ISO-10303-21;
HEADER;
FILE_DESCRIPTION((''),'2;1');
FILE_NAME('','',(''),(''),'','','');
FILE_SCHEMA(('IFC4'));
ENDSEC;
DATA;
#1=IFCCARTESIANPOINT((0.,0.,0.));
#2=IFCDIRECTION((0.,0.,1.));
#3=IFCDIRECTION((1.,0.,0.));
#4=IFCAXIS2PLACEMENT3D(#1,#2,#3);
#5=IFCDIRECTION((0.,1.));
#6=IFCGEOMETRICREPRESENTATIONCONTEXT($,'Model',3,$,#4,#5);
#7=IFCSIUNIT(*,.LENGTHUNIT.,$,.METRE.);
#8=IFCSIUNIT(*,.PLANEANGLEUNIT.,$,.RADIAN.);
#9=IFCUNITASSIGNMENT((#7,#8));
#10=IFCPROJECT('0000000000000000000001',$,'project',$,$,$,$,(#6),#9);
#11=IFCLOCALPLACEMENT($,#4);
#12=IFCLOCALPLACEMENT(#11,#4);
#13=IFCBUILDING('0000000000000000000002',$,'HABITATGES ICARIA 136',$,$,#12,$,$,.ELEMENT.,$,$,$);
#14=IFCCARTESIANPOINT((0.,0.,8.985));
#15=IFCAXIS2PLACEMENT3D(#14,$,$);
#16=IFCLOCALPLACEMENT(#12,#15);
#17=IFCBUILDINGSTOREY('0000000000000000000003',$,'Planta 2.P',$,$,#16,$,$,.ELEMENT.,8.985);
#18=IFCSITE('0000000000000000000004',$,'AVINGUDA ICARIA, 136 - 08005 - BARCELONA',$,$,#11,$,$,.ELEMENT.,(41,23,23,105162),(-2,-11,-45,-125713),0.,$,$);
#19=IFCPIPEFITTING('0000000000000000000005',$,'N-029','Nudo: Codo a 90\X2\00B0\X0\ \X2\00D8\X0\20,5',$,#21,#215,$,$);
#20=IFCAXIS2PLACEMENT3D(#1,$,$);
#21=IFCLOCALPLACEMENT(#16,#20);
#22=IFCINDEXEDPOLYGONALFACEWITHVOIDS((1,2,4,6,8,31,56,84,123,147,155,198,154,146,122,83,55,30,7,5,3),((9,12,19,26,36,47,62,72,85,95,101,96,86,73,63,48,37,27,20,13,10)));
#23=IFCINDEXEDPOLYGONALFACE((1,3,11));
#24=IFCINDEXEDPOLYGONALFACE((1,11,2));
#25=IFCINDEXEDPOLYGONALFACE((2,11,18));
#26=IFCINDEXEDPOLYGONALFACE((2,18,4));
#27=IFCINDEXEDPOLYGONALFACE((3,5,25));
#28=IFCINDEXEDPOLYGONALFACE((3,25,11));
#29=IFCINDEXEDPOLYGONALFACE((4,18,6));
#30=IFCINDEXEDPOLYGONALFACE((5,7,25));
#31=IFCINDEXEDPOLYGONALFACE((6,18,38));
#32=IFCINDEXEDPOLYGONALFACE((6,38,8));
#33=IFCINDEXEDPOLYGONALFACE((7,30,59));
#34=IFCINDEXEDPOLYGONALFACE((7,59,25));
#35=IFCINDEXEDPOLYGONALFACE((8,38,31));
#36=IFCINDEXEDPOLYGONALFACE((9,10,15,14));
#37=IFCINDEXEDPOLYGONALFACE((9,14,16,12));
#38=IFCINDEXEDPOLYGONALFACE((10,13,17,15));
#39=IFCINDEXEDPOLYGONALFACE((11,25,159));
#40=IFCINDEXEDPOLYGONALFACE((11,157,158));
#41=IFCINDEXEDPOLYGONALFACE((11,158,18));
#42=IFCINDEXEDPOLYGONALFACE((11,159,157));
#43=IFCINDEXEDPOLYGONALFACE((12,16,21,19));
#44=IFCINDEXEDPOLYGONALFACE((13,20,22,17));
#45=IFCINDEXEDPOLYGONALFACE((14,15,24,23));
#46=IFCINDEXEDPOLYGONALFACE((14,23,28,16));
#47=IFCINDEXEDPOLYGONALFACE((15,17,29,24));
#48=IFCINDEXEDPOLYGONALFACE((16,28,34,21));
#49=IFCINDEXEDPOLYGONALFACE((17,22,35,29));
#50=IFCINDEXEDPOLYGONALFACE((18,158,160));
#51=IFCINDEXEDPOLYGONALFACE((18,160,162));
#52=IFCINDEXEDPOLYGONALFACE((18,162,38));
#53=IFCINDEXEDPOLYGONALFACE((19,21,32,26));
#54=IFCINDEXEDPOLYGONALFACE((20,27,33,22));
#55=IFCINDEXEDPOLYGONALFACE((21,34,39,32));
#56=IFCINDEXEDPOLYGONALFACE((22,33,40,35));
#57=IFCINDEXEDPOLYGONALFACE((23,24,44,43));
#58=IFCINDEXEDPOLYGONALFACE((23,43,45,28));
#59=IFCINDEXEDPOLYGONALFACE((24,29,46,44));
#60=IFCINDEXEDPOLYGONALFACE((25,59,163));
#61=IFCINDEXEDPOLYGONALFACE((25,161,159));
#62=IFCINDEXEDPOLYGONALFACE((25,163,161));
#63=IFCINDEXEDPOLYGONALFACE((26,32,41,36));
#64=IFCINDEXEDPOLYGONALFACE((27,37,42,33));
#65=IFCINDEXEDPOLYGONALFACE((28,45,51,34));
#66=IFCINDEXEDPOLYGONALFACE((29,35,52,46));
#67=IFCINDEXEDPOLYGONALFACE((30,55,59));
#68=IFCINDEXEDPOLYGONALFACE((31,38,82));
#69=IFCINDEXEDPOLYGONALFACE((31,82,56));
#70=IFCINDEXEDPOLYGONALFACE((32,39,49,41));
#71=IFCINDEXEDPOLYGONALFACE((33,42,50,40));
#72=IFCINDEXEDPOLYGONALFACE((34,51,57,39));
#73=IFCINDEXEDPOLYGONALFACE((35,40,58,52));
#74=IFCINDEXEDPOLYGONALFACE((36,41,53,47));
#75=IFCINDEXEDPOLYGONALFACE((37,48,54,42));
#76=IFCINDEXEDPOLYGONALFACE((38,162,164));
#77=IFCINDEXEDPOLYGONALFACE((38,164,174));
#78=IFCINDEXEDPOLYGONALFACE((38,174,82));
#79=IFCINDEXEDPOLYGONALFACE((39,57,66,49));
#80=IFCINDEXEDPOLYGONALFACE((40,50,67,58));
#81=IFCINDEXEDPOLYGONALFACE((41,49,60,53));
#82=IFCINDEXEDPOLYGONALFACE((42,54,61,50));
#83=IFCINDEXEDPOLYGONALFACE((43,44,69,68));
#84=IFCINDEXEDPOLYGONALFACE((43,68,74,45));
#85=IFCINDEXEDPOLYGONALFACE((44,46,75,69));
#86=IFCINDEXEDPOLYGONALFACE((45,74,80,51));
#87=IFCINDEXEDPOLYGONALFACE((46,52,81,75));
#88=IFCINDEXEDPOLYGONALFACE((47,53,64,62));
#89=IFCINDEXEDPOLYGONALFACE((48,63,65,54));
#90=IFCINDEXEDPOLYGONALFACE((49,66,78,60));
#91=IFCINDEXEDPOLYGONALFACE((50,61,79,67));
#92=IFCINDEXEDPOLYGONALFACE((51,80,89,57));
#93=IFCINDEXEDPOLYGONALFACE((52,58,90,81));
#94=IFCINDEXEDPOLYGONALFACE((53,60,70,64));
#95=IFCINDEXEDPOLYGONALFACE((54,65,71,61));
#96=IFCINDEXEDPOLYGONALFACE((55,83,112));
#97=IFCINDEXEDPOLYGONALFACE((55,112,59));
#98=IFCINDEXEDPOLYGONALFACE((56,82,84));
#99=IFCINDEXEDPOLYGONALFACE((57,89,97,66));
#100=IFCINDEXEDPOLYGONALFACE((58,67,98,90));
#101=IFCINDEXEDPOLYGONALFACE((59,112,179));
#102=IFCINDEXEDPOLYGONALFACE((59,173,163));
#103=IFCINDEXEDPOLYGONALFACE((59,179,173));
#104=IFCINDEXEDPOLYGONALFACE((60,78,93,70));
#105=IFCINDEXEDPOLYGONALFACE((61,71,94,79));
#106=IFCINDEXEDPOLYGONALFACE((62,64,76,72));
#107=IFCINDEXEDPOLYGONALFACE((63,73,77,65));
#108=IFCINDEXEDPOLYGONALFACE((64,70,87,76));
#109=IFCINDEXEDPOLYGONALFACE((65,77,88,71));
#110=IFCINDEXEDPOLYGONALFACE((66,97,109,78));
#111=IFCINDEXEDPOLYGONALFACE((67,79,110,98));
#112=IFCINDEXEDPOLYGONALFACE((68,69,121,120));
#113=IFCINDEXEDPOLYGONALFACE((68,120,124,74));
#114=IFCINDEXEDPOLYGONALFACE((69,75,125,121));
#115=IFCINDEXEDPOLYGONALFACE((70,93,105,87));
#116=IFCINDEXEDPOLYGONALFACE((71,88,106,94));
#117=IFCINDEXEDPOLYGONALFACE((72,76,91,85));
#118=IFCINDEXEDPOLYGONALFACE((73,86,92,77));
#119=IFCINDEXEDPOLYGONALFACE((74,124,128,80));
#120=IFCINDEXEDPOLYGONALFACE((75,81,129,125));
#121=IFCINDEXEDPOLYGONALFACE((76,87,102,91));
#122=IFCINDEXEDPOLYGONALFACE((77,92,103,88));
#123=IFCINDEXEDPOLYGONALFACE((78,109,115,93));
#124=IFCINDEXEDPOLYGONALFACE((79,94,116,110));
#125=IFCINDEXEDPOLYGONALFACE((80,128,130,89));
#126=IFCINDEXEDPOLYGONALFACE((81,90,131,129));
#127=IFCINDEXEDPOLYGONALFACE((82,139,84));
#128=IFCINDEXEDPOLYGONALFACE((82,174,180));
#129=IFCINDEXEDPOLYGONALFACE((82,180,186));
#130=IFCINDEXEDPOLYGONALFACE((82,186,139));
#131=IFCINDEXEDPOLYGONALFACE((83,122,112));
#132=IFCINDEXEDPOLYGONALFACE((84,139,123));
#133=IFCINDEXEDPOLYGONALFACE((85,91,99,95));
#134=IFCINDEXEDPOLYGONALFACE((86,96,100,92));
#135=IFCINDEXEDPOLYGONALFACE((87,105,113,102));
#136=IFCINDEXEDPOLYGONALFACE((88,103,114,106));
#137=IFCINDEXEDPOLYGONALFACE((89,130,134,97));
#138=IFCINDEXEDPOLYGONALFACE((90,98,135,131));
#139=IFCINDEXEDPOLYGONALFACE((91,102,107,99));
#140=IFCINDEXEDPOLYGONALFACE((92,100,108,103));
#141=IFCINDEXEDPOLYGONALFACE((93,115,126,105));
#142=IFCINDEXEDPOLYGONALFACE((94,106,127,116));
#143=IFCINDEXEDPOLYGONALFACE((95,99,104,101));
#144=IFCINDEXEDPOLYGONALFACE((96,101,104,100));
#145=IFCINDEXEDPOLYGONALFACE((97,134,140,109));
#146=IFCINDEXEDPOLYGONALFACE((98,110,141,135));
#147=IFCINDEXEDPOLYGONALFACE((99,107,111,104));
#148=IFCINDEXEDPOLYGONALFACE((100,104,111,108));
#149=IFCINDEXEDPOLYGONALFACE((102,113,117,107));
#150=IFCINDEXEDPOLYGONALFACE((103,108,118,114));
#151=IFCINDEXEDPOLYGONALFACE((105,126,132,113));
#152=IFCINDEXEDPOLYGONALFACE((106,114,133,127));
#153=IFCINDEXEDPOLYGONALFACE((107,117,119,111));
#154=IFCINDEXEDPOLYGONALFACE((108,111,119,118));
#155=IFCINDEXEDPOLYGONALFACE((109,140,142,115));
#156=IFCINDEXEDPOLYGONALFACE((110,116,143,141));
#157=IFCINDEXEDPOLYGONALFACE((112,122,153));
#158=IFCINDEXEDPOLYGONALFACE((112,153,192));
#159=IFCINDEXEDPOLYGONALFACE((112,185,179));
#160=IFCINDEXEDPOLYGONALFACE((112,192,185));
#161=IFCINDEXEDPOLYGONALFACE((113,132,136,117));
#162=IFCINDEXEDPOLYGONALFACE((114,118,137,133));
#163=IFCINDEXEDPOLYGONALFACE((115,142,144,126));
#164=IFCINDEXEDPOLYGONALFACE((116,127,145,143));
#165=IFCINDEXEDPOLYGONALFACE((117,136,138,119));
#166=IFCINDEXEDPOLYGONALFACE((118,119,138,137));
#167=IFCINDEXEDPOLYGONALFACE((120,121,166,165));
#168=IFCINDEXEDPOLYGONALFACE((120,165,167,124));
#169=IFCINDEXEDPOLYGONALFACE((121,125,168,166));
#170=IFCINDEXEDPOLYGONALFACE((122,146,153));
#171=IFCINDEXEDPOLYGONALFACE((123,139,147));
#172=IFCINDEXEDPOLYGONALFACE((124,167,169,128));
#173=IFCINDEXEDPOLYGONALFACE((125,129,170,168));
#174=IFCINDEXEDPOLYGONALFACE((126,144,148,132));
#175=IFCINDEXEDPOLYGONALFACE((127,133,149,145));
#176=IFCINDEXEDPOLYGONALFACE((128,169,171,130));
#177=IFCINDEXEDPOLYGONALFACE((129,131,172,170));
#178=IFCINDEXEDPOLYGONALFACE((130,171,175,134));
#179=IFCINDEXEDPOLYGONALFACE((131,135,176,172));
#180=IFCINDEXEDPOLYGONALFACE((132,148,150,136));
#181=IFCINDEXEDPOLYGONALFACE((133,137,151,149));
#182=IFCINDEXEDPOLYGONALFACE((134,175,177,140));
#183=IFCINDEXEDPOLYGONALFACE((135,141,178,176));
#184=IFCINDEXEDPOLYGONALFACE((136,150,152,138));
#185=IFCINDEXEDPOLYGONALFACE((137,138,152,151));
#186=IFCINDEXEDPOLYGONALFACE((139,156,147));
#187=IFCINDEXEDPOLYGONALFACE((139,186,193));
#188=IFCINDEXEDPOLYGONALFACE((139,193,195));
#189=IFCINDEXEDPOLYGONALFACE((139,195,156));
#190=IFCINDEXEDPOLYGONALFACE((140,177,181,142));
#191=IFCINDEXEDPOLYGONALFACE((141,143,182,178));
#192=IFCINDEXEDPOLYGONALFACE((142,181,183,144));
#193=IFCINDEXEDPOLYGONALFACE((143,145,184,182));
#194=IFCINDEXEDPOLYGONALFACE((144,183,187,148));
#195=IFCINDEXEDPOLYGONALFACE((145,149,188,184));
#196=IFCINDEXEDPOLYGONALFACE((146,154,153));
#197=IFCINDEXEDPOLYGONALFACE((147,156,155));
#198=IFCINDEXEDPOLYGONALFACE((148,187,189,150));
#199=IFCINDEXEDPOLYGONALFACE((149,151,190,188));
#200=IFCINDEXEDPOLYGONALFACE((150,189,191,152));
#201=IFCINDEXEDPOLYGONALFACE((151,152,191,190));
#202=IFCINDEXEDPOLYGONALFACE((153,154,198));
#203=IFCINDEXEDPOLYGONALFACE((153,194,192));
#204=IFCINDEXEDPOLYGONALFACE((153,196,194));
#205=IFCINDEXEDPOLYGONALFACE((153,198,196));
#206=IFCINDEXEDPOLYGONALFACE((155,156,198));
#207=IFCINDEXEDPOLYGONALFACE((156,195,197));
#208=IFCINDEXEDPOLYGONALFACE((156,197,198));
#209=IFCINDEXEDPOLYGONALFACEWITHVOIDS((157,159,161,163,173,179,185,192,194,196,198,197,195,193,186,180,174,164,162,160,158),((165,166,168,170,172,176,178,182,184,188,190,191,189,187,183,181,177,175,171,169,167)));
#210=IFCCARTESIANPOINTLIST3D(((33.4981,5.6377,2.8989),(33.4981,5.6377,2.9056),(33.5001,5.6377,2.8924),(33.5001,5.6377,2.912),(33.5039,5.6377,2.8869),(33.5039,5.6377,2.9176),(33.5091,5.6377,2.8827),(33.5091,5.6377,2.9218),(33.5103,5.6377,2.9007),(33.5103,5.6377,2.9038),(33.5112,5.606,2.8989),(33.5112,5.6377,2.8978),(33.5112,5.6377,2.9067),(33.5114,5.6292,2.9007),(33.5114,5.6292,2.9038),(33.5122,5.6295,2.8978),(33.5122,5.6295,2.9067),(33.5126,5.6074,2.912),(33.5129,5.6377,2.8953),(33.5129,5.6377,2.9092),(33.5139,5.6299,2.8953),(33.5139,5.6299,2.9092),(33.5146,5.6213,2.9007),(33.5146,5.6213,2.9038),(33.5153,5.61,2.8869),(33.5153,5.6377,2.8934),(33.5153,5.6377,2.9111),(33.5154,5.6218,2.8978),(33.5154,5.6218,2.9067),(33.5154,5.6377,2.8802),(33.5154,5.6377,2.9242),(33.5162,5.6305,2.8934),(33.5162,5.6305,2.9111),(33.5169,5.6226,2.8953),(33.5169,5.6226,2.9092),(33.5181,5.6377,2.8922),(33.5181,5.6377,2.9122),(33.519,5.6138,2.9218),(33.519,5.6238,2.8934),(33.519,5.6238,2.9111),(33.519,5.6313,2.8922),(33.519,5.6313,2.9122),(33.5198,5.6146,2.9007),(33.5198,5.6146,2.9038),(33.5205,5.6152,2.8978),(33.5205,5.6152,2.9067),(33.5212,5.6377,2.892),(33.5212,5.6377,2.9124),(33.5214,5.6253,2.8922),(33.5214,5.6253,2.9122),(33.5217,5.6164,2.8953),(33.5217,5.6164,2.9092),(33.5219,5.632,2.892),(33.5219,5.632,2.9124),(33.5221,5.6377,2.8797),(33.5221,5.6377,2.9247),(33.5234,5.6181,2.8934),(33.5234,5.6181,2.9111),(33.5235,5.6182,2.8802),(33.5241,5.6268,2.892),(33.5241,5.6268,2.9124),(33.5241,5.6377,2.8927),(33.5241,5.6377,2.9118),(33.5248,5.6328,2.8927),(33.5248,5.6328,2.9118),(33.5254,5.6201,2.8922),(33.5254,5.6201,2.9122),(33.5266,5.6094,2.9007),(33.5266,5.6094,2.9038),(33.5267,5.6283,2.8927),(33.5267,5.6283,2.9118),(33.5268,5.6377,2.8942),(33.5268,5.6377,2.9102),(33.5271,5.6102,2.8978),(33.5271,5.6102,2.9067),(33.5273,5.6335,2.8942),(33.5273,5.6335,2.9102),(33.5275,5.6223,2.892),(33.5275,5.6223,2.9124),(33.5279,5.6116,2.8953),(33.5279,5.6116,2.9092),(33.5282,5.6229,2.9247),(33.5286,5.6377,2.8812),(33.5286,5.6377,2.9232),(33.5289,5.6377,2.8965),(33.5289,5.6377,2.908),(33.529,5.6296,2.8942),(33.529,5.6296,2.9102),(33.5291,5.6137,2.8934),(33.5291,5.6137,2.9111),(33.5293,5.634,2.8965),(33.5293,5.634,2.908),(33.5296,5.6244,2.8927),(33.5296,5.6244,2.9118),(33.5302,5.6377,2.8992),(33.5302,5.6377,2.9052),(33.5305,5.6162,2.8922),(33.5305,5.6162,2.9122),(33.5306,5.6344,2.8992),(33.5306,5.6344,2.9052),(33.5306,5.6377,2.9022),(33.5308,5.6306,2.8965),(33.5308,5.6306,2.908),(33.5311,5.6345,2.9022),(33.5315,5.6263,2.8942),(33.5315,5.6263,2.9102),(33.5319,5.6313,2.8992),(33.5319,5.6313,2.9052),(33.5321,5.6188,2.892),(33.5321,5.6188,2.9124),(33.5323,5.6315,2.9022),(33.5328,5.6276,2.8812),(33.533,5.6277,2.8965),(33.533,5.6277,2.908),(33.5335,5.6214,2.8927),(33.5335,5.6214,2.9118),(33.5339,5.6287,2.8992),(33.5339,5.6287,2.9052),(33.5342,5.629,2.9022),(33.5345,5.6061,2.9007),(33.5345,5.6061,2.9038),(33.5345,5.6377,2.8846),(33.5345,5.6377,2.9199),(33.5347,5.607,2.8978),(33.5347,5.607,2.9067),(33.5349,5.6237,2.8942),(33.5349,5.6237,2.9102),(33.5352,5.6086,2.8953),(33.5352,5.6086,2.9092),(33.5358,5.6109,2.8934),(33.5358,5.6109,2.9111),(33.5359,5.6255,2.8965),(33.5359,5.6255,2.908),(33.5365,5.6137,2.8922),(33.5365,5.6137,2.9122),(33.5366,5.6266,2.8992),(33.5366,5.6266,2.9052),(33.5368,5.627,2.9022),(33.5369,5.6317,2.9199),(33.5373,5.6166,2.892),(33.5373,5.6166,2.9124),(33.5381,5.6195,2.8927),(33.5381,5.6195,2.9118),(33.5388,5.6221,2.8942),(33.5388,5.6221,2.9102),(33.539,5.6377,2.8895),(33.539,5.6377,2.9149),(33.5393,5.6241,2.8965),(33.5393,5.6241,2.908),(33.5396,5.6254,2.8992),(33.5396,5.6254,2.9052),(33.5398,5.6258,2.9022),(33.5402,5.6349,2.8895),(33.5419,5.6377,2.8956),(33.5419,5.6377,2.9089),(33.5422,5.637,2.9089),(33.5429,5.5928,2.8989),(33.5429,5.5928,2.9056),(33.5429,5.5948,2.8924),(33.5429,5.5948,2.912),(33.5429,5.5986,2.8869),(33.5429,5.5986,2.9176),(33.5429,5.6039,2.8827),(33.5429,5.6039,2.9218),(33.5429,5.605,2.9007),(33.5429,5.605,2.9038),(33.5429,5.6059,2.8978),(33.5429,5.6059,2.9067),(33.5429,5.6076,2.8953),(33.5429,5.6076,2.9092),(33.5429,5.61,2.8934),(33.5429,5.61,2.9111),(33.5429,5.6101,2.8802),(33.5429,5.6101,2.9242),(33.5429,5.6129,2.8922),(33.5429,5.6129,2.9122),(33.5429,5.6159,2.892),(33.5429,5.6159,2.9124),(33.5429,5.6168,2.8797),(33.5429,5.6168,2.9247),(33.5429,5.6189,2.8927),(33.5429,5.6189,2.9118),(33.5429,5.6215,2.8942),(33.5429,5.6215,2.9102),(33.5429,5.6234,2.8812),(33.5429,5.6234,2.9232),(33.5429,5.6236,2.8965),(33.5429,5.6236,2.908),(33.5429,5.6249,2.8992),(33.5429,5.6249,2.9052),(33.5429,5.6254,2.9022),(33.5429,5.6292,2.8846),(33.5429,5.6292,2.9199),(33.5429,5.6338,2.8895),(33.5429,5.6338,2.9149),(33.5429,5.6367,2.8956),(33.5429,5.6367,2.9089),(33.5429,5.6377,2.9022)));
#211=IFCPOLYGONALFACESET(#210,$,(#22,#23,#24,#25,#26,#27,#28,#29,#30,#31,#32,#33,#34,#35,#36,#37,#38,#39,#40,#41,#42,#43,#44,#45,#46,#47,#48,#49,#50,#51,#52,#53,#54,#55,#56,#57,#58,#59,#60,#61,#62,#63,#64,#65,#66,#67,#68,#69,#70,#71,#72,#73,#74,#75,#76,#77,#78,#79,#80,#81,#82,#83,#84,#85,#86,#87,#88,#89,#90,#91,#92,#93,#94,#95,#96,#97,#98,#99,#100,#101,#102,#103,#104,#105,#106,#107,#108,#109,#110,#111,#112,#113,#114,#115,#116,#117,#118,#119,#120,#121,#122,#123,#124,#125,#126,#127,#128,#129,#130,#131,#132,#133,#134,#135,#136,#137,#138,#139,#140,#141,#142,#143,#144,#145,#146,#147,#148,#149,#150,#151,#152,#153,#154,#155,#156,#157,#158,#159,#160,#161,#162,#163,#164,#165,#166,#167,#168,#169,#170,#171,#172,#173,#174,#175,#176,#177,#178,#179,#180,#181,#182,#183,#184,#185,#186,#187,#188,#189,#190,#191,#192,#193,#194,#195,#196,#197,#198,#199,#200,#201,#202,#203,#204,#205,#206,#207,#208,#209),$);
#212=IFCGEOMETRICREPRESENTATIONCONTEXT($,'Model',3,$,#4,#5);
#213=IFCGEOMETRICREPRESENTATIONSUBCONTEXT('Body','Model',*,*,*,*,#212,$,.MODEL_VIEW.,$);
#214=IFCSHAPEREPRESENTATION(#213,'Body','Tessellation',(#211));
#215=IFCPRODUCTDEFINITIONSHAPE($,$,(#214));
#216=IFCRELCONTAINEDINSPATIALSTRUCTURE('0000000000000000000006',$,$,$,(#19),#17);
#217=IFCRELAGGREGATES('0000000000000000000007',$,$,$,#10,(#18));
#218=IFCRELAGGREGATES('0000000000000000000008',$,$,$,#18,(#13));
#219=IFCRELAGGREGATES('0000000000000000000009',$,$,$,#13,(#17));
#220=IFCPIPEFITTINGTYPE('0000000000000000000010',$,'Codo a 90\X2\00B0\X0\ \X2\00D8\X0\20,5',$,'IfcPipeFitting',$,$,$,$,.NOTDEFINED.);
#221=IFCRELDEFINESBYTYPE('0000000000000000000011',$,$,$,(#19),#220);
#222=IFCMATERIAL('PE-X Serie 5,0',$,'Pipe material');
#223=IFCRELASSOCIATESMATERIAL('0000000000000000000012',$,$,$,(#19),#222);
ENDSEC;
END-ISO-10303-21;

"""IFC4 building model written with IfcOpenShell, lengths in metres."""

from ifc_helpers import new_model, entity, si_unit, direction, frame, origin_with_axes, place, context, subcontext, project, spatial, source, transform, mapped, material, type_object, element, save


model = new_model("IFC4")

# Units and contexts
model_context_1 = context("Model", 3, world=origin_with_axes(), true_north=direction((0.0, 1.0)))
model_context_2 = context("Model", 3, world=origin_with_axes(), true_north=direction((0.0, 1.0)))
body_context_1 = subcontext(model_context_2, "Body", "Model", "MODEL_VIEW")
ifc_project = project(units=[si_unit("LENGTHUNIT", "METRE"), si_unit("PLANEANGLEUNIT", "RADIAN")], contexts=[model_context_1])

# Site, building, storey
site_placement = place(None, origin_with_axes())
site = spatial("IfcSite", under=ifc_project, at=site_placement, Name="AVINGUDA ICARIA, 136 - 08005 - BARCELONA", CompositionType="ELEMENT", RefLatitude=(41, 23, 23, 105162), RefLongitude=(-2, -11, -45, -125713), RefElevation=0.0)
building_placement = place(site_placement, origin_with_axes())
building = spatial("IfcBuilding", under=site, at=building_placement, Name="HABITATGES ICARIA 136", CompositionType="ELEMENT")
storey_placement = place(building_placement, frame((0.0, 0.0, 8.985)))
storey = spatial("IfcBuildingStorey", under=building, at=storey_placement, Name="Planta 2.P", CompositionType="ELEMENT", Elevation=8.985)

# Shared definitions
ifc_material_1 = material(Name="PE-X Serie 5,0", Category="Pipe material")
placement_1 = place(None, origin_with_axes())
placement_2 = place(placement_1, origin_with_axes())
placement_3 = place(placement_2, frame((0.0, 0.0, 8.985)))

# Pipe fitting
pipe_fitting_type_1 = type_object("IfcPipeFittingType", Name="Codo a 90° Ø20,5", ApplicableOccurrence="IfcPipeFitting", PredefinedType="NOTDEFINED")
shared_shape_1 = source(origin_with_axes(), body_context_1, "Body", "SweptSolid", [
    entity("IfcRevolvedAreaSolid", entity("IfcCircleHollowProfileDef", "AREA", None, entity("IfcAxis2Placement2D", entity("IfcCartesianPoint", [0.0, 0.0]), entity("IfcDirection", [1.0, 0.0])), 0.0226, 0.0123), entity("IfcAxis2Placement3D", entity("IfcCartesianPoint", [0.0225, 0.0, 0.0]), entity("IfcDirection", [-1.0, 0.0, 0.0]), entity("IfcDirection", [0.0, -1.0, 0.0])), entity("IfcAxis1Placement", entity("IfcCartesianPoint", [0.0226, 0.0, 0.0]), entity("IfcDirection", [0.0, 1.0, 0.0])), 1.570796),
])
pipe_fitting_1_placement = place(placement_3, origin_with_axes())
element("IfcPipeFitting", 1, at=pipe_fitting_1_placement, inside=storey, type_object=pipe_fitting_type_1, material=ifc_material_1, Name="N-029", Description="Nudo: Codo a 90° Ø20,5", context=body_context_1, shape_type="MappedRepresentation", body=[
    mapped(shared_shape_1, transform((33.5204, 5.6151, 2.9022), x_axis=(1.0, 0.0, 0.0), y_axis=(0.0, -1.0, 0.0), z_axis=(0.0, 0.0, -1.0), scale=1.0)),
])

save(model, "model.ifc")
